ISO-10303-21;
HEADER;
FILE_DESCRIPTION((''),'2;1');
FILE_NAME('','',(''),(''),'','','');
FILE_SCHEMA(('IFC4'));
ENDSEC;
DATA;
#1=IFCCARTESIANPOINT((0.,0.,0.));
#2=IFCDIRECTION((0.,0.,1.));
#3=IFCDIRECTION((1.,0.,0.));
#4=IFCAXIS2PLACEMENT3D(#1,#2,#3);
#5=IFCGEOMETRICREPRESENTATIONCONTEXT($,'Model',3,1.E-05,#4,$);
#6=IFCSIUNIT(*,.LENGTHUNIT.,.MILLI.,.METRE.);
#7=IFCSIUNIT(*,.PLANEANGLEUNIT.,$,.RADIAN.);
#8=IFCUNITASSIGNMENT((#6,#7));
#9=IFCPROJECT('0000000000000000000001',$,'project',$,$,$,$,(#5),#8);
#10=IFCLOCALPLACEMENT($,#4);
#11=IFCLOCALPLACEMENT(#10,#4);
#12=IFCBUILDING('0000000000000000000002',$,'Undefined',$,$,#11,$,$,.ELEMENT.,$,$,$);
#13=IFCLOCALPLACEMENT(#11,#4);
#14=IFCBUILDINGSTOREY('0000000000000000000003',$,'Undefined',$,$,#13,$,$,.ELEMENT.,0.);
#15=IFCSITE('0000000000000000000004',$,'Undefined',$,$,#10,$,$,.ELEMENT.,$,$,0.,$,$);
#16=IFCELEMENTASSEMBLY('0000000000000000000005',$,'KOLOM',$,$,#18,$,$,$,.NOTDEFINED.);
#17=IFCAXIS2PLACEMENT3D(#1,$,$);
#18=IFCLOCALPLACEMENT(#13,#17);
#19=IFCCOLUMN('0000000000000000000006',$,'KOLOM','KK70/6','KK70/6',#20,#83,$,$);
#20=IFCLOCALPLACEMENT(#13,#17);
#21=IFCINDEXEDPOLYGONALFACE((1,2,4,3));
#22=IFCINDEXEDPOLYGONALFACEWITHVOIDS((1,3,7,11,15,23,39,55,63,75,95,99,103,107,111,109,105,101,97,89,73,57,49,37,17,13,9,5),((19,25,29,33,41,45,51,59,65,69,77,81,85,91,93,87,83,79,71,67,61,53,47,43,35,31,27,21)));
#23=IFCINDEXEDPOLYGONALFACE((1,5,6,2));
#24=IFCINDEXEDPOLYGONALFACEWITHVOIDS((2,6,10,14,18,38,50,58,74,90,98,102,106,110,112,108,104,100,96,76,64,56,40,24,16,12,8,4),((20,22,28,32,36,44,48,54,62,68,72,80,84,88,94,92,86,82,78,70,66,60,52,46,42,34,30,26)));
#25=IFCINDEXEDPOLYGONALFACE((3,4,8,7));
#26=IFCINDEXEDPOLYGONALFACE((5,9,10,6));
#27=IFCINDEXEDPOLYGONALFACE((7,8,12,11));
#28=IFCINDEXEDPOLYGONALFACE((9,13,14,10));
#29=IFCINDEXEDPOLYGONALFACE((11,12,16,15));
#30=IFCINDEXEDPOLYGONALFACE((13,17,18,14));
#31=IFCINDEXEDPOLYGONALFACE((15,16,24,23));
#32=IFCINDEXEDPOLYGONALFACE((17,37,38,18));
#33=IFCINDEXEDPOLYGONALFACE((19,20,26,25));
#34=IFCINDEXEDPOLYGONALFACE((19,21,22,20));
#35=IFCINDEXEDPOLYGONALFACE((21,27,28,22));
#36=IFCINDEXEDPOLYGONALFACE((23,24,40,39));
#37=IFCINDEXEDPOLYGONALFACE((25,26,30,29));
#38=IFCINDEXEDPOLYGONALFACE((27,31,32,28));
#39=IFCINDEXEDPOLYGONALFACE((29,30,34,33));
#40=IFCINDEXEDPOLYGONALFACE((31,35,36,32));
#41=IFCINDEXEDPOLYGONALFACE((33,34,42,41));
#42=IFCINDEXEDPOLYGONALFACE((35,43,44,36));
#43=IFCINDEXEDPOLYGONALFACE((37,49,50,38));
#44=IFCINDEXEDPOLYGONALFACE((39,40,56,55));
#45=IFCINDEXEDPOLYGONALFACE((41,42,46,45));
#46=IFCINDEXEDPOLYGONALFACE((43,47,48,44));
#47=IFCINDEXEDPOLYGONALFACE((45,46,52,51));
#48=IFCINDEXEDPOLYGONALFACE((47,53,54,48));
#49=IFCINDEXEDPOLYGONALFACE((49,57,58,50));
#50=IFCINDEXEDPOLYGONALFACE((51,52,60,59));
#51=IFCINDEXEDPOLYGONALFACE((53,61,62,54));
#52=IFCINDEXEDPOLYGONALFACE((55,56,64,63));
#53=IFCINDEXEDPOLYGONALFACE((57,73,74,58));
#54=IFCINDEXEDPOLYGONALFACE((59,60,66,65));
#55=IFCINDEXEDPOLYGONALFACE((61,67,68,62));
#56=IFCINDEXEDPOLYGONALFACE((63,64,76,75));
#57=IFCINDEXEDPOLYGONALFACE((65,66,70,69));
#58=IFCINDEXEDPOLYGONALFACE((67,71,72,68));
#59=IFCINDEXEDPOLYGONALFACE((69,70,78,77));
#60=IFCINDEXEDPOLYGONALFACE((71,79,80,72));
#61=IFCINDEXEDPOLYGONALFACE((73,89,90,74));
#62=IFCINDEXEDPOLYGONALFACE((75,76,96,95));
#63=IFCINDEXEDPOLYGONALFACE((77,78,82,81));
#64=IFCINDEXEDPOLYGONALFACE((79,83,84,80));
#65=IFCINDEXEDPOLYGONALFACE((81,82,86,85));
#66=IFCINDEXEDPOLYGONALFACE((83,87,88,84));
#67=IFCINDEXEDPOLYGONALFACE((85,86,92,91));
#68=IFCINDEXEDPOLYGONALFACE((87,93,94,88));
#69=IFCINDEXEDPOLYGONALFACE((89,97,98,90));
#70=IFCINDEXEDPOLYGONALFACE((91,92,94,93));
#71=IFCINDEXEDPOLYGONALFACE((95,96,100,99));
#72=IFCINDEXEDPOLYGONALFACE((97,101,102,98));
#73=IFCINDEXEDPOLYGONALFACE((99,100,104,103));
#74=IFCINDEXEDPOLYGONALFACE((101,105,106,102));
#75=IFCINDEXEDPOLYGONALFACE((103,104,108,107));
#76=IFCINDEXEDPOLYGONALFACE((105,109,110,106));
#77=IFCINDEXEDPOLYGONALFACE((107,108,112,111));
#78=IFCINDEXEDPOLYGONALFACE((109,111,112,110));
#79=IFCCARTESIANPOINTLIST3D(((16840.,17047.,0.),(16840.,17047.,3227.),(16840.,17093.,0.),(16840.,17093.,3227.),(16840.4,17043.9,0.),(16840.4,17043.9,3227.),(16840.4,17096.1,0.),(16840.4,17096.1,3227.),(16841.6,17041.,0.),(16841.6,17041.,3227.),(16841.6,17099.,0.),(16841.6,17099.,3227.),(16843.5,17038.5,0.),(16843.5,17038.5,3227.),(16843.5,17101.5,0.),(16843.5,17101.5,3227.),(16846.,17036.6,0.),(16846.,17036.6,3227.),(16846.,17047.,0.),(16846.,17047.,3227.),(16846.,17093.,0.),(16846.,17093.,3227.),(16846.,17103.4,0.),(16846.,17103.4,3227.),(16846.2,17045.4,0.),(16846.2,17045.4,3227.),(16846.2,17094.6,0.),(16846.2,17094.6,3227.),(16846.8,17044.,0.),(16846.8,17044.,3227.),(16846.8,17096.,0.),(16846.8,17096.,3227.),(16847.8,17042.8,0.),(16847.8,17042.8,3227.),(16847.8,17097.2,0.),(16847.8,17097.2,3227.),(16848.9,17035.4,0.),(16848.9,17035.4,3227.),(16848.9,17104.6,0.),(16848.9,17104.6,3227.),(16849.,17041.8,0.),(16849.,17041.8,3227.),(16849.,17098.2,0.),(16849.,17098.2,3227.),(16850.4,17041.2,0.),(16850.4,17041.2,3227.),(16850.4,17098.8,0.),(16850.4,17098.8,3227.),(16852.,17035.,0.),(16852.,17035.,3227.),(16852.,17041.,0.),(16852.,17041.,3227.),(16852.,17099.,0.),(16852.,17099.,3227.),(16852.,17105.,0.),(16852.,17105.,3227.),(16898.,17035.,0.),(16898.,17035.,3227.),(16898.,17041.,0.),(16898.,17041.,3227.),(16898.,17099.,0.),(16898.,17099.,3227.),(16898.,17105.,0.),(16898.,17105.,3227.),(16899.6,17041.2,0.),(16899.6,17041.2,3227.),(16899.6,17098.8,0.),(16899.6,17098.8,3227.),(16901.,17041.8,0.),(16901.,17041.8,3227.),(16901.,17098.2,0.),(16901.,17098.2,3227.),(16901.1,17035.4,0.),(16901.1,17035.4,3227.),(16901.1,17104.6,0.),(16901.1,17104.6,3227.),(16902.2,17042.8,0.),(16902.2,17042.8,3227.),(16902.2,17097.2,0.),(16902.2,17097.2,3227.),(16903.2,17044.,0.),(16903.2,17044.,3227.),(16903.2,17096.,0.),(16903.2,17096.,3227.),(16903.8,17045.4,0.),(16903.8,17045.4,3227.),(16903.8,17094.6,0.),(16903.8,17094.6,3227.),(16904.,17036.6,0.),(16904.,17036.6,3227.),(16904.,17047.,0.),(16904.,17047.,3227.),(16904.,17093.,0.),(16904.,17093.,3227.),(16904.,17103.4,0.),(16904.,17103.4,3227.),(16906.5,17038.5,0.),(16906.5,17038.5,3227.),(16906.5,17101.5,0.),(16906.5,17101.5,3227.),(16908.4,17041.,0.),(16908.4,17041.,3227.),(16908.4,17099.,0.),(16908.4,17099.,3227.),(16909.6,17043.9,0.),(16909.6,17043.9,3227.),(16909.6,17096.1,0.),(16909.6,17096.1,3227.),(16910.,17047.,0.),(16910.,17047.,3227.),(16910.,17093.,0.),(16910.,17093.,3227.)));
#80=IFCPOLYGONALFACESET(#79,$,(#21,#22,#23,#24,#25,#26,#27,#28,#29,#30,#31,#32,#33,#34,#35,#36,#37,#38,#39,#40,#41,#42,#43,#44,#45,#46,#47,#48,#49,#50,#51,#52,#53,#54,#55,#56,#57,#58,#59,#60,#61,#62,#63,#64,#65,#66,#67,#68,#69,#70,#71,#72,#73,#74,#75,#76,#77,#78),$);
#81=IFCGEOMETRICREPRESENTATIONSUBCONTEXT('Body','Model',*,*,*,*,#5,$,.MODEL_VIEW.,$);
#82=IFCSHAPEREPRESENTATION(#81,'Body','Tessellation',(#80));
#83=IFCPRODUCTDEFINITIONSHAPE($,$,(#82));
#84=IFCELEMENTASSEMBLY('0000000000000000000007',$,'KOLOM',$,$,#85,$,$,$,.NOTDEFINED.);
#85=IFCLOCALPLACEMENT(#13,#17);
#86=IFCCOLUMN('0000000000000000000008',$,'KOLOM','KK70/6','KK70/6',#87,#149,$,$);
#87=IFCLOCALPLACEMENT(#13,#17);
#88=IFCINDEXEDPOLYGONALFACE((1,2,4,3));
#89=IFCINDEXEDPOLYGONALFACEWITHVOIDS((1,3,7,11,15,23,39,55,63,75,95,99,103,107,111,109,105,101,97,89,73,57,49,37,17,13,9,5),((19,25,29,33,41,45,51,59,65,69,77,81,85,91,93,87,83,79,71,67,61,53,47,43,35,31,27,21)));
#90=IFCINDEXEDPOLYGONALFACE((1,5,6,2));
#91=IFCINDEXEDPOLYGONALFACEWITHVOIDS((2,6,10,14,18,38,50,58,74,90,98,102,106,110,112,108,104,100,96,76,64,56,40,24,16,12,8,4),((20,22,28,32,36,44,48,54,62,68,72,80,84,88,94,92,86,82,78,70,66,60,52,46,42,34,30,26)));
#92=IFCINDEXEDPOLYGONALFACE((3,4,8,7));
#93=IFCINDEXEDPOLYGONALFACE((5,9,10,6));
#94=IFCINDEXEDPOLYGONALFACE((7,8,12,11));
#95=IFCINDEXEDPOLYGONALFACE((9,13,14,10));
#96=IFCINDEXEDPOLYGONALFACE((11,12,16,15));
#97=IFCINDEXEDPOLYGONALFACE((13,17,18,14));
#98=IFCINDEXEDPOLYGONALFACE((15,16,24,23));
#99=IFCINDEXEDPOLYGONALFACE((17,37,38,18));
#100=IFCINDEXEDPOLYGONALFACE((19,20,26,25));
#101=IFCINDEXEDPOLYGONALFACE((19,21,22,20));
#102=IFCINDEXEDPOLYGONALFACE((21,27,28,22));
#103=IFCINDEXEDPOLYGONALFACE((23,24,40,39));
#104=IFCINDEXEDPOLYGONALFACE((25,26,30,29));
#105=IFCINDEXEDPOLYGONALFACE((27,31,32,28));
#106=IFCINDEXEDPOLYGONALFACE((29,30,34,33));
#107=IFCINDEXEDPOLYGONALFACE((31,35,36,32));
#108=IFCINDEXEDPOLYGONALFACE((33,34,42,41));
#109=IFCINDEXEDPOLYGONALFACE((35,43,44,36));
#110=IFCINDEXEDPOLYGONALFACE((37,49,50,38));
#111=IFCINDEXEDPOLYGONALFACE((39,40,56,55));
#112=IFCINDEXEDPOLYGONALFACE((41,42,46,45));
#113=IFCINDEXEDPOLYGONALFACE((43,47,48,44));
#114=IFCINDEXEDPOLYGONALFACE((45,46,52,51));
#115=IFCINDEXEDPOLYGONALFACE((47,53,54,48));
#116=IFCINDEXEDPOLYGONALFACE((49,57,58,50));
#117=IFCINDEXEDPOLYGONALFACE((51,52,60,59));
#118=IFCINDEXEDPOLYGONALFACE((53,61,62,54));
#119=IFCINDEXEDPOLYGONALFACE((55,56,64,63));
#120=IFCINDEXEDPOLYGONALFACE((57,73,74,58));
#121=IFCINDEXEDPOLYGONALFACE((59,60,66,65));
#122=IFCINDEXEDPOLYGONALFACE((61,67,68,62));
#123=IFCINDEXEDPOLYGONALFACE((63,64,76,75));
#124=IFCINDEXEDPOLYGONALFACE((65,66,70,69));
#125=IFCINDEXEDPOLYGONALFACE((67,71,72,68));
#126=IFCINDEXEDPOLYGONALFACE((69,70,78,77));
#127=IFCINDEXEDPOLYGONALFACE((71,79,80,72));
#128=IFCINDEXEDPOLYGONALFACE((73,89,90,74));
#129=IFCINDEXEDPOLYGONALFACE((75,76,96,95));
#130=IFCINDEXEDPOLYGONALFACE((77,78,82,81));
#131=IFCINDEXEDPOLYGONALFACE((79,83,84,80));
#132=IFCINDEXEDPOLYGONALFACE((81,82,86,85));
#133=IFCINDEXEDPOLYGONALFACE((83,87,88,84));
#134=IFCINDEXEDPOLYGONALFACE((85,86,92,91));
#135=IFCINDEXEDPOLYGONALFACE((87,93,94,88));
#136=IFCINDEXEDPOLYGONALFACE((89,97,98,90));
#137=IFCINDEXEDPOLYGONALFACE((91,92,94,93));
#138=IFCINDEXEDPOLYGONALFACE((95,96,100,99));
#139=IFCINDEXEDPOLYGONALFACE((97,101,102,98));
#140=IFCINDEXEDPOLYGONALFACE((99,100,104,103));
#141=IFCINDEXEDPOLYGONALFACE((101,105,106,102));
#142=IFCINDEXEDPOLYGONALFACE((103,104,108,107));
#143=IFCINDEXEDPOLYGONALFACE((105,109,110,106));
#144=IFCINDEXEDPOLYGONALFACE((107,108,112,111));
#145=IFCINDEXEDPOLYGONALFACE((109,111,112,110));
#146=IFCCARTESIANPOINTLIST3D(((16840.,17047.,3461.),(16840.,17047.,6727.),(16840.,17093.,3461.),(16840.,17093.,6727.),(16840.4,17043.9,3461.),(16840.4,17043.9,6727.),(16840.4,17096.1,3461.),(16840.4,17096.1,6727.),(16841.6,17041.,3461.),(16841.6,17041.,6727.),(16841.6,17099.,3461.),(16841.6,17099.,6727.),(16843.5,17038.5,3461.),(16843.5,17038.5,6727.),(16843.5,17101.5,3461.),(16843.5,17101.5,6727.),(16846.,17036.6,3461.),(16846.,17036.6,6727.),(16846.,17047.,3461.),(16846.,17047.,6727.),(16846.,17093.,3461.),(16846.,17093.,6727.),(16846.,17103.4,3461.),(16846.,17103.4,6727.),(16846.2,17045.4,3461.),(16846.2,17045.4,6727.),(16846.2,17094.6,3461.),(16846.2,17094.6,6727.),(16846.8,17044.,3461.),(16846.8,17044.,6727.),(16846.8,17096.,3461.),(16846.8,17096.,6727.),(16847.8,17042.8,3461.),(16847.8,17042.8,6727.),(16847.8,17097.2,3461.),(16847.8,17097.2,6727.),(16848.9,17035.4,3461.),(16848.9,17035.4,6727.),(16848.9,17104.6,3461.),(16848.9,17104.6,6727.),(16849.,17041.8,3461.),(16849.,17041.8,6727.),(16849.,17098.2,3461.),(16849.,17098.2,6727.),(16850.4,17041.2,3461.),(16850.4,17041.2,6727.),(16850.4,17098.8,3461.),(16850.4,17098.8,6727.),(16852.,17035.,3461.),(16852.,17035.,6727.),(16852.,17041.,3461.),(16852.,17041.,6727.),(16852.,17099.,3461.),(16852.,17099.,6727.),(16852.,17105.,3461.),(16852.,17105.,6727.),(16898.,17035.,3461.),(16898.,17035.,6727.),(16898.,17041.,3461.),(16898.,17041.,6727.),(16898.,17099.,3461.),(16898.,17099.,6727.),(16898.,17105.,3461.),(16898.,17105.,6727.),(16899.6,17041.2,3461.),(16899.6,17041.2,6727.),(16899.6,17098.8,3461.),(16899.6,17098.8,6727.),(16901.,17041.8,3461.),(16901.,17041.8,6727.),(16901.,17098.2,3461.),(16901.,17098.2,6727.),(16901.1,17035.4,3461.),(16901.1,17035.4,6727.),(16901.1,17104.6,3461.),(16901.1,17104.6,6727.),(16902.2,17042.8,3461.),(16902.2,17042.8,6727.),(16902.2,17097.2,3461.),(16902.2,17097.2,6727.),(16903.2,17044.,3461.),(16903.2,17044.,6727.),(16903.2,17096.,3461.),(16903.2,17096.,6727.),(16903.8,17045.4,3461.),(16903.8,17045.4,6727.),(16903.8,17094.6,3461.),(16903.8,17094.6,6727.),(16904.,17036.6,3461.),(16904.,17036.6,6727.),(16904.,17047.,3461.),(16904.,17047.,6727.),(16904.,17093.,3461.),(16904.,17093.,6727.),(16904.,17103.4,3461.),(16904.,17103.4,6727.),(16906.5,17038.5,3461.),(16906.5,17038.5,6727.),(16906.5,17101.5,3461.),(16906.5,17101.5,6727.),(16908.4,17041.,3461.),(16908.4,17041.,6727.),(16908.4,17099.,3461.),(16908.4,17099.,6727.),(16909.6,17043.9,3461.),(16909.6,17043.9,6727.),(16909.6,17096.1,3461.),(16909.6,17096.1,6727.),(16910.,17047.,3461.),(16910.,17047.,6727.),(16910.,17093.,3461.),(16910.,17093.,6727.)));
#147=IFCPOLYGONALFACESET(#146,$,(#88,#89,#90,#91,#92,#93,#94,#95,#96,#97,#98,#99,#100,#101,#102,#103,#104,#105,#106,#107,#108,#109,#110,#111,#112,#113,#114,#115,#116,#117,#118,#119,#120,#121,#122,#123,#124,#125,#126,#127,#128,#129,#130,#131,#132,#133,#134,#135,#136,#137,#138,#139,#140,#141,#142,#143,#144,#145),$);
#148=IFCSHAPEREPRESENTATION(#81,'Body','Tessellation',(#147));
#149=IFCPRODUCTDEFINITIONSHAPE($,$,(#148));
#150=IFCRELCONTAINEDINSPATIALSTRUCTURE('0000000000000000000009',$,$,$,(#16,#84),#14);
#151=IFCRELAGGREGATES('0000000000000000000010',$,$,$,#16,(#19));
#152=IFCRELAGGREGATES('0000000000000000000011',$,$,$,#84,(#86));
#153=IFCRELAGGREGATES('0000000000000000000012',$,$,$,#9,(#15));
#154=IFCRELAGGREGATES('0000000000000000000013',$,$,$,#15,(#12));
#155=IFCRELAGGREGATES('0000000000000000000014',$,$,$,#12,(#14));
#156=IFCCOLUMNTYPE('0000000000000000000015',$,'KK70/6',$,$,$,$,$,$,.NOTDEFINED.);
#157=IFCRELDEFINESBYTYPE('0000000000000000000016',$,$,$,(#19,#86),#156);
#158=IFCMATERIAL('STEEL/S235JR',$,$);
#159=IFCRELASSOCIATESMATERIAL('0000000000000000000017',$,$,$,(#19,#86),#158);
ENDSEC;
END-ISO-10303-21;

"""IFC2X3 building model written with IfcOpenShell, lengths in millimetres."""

from ifc_helpers import new_model, si_unit, frame, origin_with_axes, origin_2d_with_axis, place, context, subcontext, project, spatial, hollow_rectangle, extrude, material, type_object, element, aggregate, save


model = new_model("IFC2X3")

# Units and contexts
model_context = context("Model", 3, precision=1e-05, world=origin_with_axes())
body_context = subcontext(model_context, "Body", "Model", "MODEL_VIEW")
ifc_project = project(units=[si_unit("LENGTHUNIT", "METRE", prefix="MILLI"), si_unit("PLANEANGLEUNIT", "RADIAN")], contexts=[model_context])

# Site, building, storey
site_placement = place(None, origin_with_axes())
site = spatial("IfcSite", under=ifc_project, at=site_placement, Name="Undefined", CompositionType="ELEMENT", RefElevation=0.0)
building_placement = place(site_placement, origin_with_axes())
building = spatial("IfcBuilding", under=site, at=building_placement, Name="Undefined", CompositionType="ELEMENT")
storey_placement = place(building_placement, origin_with_axes())
storey = spatial("IfcBuildingStorey", under=building, at=storey_placement, Name="Undefined", CompositionType="ELEMENT", Elevation=0.0)

# Element assemblies, columns
assembly_1_placement = place(storey_placement, origin_with_axes())
assembly_1 = element("IfcElementAssembly", 1, at=assembly_1_placement, inside=storey, Name="KOLOM", PredefinedType="NOTDEFINED")
ifc_material = material(Name="STEEL/S235JR")
column_type = type_object("IfcColumnType", Name="KK70/6", PredefinedType="NOTDEFINED")
column_1_placement = place(assembly_1_placement, frame((16875.0, 17070.0, 0.0), z_axis=(0.0, 0.0, 1.0), x_axis=(1.0, 0.0, 0.0)))
column_1 = element("IfcColumn", 2, at=column_1_placement, type_object=column_type, material=ifc_material, Name="KOLOM", Description="KK70/6", ObjectType="KK70/6", context=body_context, shape_type="SweptSolid", body=[
    extrude(hollow_rectangle(XDim=70.0, YDim=70.0, WallThickness=6.0, InnerFilletRadius=6.0, OuterFilletRadius=12.0, at=origin_2d_with_axis()), frame((0.0, 0.0, 3227.0), z_axis=(0.0, 0.0, -1.0), x_axis=(0.0, -1.0, 0.0)), (0.0, 0.0, 1.0), 3227.0),
])
assembly_2_placement = place(storey_placement, origin_with_axes())
assembly_2 = element("IfcElementAssembly", 3, at=assembly_2_placement, inside=storey, Name="KOLOM", PredefinedType="NOTDEFINED")
column_2_placement = place(assembly_2_placement, frame((16875.0, 17070.0, 3450.0), z_axis=(0.0, 0.0, 1.0), x_axis=(1.0, 0.0, 0.0)))
column_2 = element("IfcColumn", 4, at=column_2_placement, type_object=column_type, material=ifc_material, Name="KOLOM", Description="KK70/6", ObjectType="KK70/6", context=body_context, shape_type="SweptSolid", body=[
    extrude(hollow_rectangle(XDim=70.0, YDim=70.0, WallThickness=6.0, InnerFilletRadius=6.0, OuterFilletRadius=12.0, at=origin_2d_with_axis()), frame((0.0, 0.0, 3277.0), z_axis=(0.0, 0.0, -1.0), x_axis=(0.0, -1.0, 0.0)), (0.0, 0.0, 1.0), 3266.0),
])

aggregate(assembly_1, [column_1])
aggregate(assembly_2, [column_2])

save(model, "model.ifc")
